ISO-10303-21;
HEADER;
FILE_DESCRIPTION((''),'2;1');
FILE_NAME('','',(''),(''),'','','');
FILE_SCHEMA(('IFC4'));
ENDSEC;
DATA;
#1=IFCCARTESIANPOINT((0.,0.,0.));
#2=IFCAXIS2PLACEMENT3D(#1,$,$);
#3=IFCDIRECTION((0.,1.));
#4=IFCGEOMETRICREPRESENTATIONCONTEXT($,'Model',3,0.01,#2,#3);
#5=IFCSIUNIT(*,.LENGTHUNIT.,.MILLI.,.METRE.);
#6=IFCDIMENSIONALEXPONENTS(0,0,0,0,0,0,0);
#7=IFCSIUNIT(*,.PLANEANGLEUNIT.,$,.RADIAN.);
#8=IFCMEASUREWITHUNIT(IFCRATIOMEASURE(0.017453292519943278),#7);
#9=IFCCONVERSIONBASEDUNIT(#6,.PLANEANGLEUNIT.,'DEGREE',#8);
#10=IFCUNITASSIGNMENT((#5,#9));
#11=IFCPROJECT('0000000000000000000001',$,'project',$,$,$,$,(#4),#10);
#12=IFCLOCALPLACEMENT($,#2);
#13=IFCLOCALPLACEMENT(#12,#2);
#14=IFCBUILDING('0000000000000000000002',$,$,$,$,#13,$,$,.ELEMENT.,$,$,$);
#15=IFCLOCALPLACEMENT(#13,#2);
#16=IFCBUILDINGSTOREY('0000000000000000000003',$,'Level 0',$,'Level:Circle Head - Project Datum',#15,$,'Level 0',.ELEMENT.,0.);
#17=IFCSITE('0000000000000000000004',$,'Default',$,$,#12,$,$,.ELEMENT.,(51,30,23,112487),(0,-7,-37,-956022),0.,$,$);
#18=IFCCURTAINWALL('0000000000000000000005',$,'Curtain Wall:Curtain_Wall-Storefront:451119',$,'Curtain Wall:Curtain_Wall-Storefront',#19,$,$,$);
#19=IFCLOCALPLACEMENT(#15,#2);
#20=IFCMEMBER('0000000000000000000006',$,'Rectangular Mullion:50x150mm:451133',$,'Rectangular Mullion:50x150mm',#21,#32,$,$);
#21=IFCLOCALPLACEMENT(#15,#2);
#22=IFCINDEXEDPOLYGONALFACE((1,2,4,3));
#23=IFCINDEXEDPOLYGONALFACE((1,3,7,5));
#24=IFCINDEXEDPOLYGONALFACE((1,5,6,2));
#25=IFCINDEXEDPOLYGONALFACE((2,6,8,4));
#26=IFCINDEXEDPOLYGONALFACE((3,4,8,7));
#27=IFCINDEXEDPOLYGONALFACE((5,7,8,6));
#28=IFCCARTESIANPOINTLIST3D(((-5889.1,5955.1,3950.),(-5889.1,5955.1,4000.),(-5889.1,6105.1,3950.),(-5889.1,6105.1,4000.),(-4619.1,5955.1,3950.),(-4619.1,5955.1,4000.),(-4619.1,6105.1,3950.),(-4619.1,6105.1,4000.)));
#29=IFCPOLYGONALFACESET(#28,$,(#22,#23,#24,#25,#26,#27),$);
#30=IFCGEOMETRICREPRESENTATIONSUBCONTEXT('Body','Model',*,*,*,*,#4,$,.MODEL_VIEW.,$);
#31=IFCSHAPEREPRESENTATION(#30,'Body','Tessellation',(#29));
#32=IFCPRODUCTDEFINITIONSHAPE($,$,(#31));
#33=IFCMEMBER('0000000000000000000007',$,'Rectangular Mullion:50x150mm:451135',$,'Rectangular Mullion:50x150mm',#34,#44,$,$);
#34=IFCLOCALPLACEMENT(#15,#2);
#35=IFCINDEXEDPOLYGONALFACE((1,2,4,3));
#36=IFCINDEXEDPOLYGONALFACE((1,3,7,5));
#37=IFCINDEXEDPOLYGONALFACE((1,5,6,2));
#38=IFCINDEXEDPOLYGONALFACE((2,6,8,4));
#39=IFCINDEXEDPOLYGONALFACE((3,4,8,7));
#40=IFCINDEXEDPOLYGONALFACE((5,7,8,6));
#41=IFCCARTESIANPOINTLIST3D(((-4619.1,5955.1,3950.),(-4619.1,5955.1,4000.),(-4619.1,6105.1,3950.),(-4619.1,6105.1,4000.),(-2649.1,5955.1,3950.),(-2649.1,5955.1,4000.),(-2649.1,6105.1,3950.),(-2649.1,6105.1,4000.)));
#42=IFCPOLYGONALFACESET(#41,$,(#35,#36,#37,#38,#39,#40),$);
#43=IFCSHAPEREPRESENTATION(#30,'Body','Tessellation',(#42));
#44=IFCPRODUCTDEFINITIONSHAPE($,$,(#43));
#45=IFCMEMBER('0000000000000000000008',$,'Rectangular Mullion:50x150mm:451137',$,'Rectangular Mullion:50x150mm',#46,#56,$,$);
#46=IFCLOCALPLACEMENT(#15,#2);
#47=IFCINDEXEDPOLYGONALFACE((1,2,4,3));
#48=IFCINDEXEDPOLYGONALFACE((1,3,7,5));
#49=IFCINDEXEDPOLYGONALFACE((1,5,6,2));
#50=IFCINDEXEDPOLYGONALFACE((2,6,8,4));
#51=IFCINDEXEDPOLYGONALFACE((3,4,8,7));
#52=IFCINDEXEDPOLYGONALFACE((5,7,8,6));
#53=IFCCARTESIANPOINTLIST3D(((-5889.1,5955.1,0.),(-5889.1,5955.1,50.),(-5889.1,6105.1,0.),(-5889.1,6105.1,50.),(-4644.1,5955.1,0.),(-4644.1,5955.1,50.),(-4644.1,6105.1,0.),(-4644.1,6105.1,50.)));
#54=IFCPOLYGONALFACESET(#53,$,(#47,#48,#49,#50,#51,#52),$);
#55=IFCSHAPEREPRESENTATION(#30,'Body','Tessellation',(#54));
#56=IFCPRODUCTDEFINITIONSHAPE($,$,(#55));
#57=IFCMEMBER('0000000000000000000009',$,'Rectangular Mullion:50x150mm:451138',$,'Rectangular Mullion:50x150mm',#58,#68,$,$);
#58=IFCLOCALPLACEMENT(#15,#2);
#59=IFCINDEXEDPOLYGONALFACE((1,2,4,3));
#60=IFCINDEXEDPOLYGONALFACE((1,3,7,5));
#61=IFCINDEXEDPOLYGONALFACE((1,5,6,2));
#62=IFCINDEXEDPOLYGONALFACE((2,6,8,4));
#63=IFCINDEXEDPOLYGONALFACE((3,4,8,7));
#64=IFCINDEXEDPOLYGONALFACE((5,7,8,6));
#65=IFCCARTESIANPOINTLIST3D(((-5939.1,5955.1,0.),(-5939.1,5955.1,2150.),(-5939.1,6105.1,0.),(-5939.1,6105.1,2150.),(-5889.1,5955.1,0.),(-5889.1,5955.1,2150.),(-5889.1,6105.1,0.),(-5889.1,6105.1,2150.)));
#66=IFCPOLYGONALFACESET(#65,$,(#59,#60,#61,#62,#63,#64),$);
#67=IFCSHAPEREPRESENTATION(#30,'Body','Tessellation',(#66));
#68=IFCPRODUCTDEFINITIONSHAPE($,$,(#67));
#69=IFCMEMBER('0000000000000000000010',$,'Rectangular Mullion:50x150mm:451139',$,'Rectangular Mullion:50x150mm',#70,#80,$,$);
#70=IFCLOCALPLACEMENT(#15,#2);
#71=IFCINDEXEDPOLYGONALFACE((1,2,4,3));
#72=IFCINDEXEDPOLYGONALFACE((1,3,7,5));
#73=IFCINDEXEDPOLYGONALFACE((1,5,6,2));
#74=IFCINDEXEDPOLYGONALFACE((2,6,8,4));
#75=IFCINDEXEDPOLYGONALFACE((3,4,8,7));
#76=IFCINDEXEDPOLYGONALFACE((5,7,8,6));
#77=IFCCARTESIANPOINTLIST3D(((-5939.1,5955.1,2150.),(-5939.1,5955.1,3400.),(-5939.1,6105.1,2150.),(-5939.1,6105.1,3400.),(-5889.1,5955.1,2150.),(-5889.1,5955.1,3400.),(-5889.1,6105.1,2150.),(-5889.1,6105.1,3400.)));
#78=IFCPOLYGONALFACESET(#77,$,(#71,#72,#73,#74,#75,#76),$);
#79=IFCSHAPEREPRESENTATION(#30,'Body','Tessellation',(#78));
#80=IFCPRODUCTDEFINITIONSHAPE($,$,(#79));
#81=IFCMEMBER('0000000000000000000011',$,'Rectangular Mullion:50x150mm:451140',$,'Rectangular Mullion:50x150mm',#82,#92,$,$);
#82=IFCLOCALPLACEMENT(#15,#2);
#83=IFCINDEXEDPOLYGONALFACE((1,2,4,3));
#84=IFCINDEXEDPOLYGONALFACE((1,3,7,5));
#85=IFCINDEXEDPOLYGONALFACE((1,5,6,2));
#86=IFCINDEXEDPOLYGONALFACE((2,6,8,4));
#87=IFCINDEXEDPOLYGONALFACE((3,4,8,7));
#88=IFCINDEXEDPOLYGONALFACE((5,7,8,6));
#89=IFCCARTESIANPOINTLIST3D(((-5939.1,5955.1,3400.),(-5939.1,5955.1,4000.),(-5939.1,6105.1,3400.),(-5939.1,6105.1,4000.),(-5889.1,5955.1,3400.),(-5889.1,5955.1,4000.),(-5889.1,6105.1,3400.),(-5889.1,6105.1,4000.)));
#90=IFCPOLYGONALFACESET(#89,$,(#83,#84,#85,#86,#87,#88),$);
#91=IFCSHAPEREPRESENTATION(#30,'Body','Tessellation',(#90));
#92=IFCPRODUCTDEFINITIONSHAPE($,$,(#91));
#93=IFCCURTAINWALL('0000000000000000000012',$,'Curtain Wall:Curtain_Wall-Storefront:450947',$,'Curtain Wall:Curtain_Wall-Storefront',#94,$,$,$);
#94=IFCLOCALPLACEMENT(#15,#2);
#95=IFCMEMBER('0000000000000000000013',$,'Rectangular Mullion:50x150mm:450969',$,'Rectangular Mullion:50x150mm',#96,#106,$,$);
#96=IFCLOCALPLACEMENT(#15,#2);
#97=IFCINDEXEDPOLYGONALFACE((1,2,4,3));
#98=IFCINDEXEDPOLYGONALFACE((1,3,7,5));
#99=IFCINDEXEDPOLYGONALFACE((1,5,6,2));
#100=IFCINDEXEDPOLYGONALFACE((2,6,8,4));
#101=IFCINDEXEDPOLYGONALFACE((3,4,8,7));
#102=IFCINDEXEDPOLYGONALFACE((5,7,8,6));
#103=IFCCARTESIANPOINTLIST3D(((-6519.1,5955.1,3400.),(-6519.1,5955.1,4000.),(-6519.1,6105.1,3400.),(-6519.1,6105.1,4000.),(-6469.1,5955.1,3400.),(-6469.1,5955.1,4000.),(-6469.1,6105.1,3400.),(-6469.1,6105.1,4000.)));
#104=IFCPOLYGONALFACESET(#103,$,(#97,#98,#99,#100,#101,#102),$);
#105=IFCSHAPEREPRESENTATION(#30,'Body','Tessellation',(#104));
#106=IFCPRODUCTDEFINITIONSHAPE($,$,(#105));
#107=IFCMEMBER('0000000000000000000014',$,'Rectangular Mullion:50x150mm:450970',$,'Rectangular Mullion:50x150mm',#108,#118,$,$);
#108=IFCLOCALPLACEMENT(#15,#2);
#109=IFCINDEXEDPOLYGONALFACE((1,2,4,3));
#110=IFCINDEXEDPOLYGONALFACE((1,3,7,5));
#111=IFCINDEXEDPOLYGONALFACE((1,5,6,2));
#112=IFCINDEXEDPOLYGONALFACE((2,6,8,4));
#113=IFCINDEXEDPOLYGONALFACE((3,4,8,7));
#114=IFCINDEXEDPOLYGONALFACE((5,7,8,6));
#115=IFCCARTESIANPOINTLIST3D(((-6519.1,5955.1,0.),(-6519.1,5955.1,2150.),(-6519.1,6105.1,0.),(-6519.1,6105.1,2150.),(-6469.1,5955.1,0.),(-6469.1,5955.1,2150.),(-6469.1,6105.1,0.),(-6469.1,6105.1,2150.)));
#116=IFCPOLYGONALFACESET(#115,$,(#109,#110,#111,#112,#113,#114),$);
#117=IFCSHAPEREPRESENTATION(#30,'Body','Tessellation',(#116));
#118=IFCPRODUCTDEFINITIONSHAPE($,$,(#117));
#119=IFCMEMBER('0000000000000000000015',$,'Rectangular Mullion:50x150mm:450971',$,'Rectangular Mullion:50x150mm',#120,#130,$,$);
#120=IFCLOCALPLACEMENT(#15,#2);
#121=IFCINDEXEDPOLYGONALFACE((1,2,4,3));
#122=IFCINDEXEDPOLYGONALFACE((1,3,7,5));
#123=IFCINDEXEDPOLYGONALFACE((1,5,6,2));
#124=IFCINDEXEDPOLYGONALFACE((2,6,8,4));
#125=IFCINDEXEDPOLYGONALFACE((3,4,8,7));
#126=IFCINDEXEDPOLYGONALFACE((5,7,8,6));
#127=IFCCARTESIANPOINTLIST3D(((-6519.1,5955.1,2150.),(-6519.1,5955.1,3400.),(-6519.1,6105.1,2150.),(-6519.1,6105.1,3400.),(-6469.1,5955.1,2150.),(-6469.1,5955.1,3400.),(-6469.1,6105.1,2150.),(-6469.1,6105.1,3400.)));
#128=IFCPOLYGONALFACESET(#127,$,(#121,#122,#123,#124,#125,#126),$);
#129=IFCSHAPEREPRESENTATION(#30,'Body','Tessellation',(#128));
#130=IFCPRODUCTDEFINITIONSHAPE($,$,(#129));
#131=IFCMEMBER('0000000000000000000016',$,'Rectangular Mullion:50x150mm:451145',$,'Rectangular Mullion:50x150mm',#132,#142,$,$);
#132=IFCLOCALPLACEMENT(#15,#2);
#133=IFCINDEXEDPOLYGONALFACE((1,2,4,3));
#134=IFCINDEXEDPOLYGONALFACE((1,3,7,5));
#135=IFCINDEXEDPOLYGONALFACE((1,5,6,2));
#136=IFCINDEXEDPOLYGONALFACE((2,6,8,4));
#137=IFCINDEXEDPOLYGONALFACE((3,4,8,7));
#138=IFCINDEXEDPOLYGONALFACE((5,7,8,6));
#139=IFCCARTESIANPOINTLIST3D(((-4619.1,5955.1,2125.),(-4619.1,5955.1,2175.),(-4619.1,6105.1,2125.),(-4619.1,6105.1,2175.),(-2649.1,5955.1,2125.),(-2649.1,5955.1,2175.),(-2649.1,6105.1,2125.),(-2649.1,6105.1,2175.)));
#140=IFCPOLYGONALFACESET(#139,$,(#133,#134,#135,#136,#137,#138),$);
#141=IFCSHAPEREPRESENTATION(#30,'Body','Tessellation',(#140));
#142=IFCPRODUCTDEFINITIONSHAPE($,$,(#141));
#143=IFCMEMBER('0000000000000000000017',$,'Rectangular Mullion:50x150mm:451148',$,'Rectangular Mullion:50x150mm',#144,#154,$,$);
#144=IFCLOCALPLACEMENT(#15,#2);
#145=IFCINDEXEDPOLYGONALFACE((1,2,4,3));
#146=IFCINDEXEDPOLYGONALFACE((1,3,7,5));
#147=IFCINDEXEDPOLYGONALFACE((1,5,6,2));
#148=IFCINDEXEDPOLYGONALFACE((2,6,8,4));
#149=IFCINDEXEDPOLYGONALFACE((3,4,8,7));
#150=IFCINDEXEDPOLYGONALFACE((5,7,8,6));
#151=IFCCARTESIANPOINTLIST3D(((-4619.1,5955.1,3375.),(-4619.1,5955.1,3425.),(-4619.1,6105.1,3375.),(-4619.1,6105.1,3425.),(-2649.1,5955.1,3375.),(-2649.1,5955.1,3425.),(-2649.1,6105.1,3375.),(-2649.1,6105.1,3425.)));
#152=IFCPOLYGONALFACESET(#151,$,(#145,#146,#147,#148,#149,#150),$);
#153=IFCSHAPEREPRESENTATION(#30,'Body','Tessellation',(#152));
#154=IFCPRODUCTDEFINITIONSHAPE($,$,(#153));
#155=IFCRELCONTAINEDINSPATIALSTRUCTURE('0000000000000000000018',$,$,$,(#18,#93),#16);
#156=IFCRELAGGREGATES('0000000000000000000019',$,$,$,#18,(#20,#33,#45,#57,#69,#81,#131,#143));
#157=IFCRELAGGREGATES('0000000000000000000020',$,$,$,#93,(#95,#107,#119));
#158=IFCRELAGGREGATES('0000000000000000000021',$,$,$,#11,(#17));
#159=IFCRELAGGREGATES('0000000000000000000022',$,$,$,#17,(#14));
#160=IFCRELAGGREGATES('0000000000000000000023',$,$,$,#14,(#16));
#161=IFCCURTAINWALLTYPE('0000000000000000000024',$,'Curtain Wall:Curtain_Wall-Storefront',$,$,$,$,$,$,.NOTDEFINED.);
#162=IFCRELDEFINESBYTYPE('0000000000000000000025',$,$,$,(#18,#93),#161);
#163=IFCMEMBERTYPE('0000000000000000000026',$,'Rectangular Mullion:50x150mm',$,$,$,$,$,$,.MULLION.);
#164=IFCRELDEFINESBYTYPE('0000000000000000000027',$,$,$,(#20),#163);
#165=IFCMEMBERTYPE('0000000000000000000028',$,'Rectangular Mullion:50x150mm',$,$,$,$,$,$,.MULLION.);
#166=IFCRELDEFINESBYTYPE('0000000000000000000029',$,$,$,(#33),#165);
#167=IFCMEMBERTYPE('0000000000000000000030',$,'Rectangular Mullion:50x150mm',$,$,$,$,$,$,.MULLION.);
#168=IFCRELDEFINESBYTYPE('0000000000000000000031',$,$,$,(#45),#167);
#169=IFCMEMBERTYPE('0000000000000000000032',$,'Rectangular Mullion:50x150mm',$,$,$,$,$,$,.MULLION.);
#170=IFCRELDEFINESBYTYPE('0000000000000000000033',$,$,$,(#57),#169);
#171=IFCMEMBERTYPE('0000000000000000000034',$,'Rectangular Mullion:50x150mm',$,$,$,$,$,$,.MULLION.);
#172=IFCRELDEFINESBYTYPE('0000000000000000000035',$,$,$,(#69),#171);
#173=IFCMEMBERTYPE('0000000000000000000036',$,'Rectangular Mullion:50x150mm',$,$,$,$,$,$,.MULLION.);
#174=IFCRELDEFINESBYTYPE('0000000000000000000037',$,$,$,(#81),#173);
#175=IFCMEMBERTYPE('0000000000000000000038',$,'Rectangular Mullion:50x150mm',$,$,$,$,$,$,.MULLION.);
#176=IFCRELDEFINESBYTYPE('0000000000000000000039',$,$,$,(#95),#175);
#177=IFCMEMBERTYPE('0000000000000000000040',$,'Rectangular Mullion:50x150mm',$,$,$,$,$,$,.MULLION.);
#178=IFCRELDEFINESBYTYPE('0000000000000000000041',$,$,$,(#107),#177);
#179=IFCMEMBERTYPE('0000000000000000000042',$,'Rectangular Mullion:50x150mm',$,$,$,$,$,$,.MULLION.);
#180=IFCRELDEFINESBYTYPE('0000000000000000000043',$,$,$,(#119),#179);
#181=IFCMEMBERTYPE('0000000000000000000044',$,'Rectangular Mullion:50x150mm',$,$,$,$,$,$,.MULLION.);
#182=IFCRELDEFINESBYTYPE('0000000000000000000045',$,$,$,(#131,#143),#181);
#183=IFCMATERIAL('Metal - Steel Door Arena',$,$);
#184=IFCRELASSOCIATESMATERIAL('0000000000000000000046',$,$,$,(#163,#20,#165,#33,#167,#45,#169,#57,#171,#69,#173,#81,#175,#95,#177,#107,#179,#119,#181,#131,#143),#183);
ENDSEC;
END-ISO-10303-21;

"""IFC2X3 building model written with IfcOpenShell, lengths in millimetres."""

from ifc_helpers import new_model, entity, si_unit, converted_unit, direction, frame, origin, origin_2d_with_axis, place, context, subcontext, project, spatial, rectangle, extrude, source, transform, mapped, material, type_object, type_shapes, element, aggregate, save


model = new_model("IFC2X3")

# Units and contexts
model_context = context("Model", 3, precision=0.01, world=origin(), true_north=direction((0.0, 1.0)))
body_context = subcontext(model_context, "Body", "Model", "MODEL_VIEW")
ifc_project = project(units=[si_unit("LENGTHUNIT", "METRE", prefix="MILLI"), converted_unit("PLANEANGLEUNIT", "DEGREE", entity("IfcRatioMeasure", 0.017453292519943278), si_unit("PLANEANGLEUNIT", "RADIAN"), dimensions=[0, 0, 0, 0, 0, 0, 0])], contexts=[model_context])

# Site, building, storey
site_placement = place(None, origin())
site = spatial("IfcSite", under=ifc_project, at=site_placement, Name="Default", CompositionType="ELEMENT", RefLatitude=(51, 30, 23, 112487), RefLongitude=(0, -7, -37, -956022), RefElevation=0.0)
building_placement = place(site_placement, origin())
building = spatial("IfcBuilding", under=site, at=building_placement, CompositionType="ELEMENT")
storey_placement = place(building_placement, origin())
storey = spatial("IfcBuildingStorey", under=building, at=storey_placement, Name="Level 0", ObjectType="Level:Circle Head - Project Datum", LongName="Level 0", CompositionType="ELEMENT", Elevation=0.0)

# Curtain walls, members
curtain_wall_type = type_object("IfcCurtainWallType", Name="Curtain Wall:Curtain_Wall-Storefront", PredefinedType="NOTDEFINED")
curtain_wall_1_placement = place(storey_placement, origin())
curtain_wall_1 = element("IfcCurtainWall", 1, at=curtain_wall_1_placement, inside=storey, type_object=curtain_wall_type, Name="Curtain Wall:Curtain_Wall-Storefront:451119", ObjectType="Curtain Wall:Curtain_Wall-Storefront")
ifc_material_1 = material(Name="Metal - Steel Door Arena")
member_type_1 = type_object("IfcMemberType", Name="Rectangular Mullion:50x150mm", PredefinedType="MULLION", material=ifc_material_1)
shared_shape_1 = source(origin(), body_context, "Body", "SweptSolid", [
    extrude(rectangle(XDim=150.0, YDim=50.0, at=origin_2d_with_axis()), frame((-25.0, 0.0, -1270.0), z_axis=(0.0, 0.0, 1.0), x_axis=(0.0, -1.0, 0.0)), (0.0, 0.0, 1.0), 1270.0),
])
type_shapes(member_type_1, [shared_shape_1])
member_1_placement = place(curtain_wall_1_placement, frame((-5889.1, 6030.1, 4000.0), z_axis=(-1.0, 0.0, 0.0), x_axis=(0.0, 0.0, 1.0)))
member_1 = element("IfcMember", 2, at=member_1_placement, type_object=member_type_1, material=ifc_material_1, Name="Rectangular Mullion:50x150mm:451133", ObjectType="Rectangular Mullion:50x150mm", context=body_context, shape_type="MappedRepresentation", body=[
    mapped(shared_shape_1, transform((0.0, 0.0, 0.0), scale=1.0)),
])
member_type_2 = type_object("IfcMemberType", Name="Rectangular Mullion:50x150mm", PredefinedType="MULLION", material=ifc_material_1)
shared_shape_2 = source(origin(), body_context, "Body", "SweptSolid", [
    extrude(rectangle(XDim=150.0, YDim=50.0, at=origin_2d_with_axis()), frame((-25.0, 0.0, -1970.0), z_axis=(0.0, 0.0, 1.0), x_axis=(0.0, -1.0, 0.0)), (0.0, 0.0, 1.0), 1970.0),
])
type_shapes(member_type_2, [shared_shape_2])
member_2_placement = place(curtain_wall_1_placement, frame((-4619.1, 6030.1, 4000.0), z_axis=(-1.0, 0.0, 0.0), x_axis=(0.0, 0.0, 1.0)))
member_2 = element("IfcMember", 3, at=member_2_placement, type_object=member_type_2, material=ifc_material_1, Name="Rectangular Mullion:50x150mm:451135", ObjectType="Rectangular Mullion:50x150mm", context=body_context, shape_type="MappedRepresentation", body=[
    mapped(shared_shape_2, transform((0.0, 0.0, 0.0), scale=1.0)),
])
member_type_3 = type_object("IfcMemberType", Name="Rectangular Mullion:50x150mm", PredefinedType="MULLION", material=ifc_material_1)
shared_shape_3 = source(origin(), body_context, "Body", "SweptSolid", [
    extrude(rectangle(XDim=150.0, YDim=50.0, at=origin_2d_with_axis()), frame((-25.0, 0.0, -1245.0), z_axis=(0.0, 0.0, 1.0), x_axis=(0.0, -1.0, 0.0)), (0.0, 0.0, 1.0), 1245.0),
])
type_shapes(member_type_3, [shared_shape_3])
member_3_placement = place(curtain_wall_1_placement, frame((-4644.1, 6030.1, 0.0), z_axis=(1.0, 0.0, 0.0), x_axis=(0.0, 0.0, -1.0)))
member_3 = element("IfcMember", 4, at=member_3_placement, type_object=member_type_3, material=ifc_material_1, Name="Rectangular Mullion:50x150mm:451137", ObjectType="Rectangular Mullion:50x150mm", context=body_context, shape_type="MappedRepresentation", body=[
    mapped(shared_shape_3, transform((0.0, 0.0, 0.0), scale=1.0)),
])
member_type_4 = type_object("IfcMemberType", Name="Rectangular Mullion:50x150mm", PredefinedType="MULLION", material=ifc_material_1)
shared_shape_4 = source(origin(), body_context, "Body", "SweptSolid", [
    extrude(rectangle(XDim=150.0, YDim=50.0, at=origin_2d_with_axis()), frame((-25.0, 0.0, -2150.0), z_axis=(0.0, 0.0, 1.0), x_axis=(0.0, -1.0, 0.0)), (0.0, 0.0, 1.0), 2150.0),
])
type_shapes(member_type_4, [shared_shape_4])
member_4_placement = place(curtain_wall_1_placement, frame((-5939.1, 6030.1, 0.0), z_axis=(0.0, 0.0, -1.0), x_axis=(-1.0, 0.0, 0.0)))
member_4 = element("IfcMember", 5, at=member_4_placement, type_object=member_type_4, material=ifc_material_1, Name="Rectangular Mullion:50x150mm:451138", ObjectType="Rectangular Mullion:50x150mm", context=body_context, shape_type="MappedRepresentation", body=[
    mapped(shared_shape_4, transform((0.0, 0.0, 0.0), scale=1.0)),
])
member_type_5 = type_object("IfcMemberType", Name="Rectangular Mullion:50x150mm", PredefinedType="MULLION", material=ifc_material_1)
shared_shape_5 = source(origin(), body_context, "Body", "SweptSolid", [
    extrude(rectangle(XDim=150.0, YDim=50.0, at=origin_2d_with_axis()), frame((-25.0, 0.0, -1250.0), z_axis=(0.0, 0.0, 1.0), x_axis=(0.0, -1.0, 0.0)), (0.0, 0.0, 1.0), 1250.0),
])
type_shapes(member_type_5, [shared_shape_5])
member_5_placement = place(curtain_wall_1_placement, frame((-5939.1, 6030.1, 2150.0), z_axis=(0.0, 0.0, -1.0), x_axis=(-1.0, 0.0, 0.0)))
member_5 = element("IfcMember", 6, at=member_5_placement, type_object=member_type_5, material=ifc_material_1, Name="Rectangular Mullion:50x150mm:451139", ObjectType="Rectangular Mullion:50x150mm", context=body_context, shape_type="MappedRepresentation", body=[
    mapped(shared_shape_5, transform((0.0, 0.0, 0.0), scale=1.0)),
])
member_type_6 = type_object("IfcMemberType", Name="Rectangular Mullion:50x150mm", PredefinedType="MULLION", material=ifc_material_1)
shared_shape_6 = source(origin(), body_context, "Body", "SweptSolid", [
    extrude(rectangle(XDim=150.0, YDim=50.0, at=origin_2d_with_axis()), frame((-25.0, 0.0, -600.0), z_axis=(0.0, 0.0, 1.0), x_axis=(0.0, -1.0, 0.0)), (0.0, 0.0, 1.0), 600.0),
])
type_shapes(member_type_6, [shared_shape_6])
member_6_placement = place(curtain_wall_1_placement, frame((-5939.1, 6030.1, 3400.0), z_axis=(0.0, 0.0, -1.0), x_axis=(-1.0, 0.0, 0.0)))
member_6 = element("IfcMember", 7, at=member_6_placement, type_object=member_type_6, material=ifc_material_1, Name="Rectangular Mullion:50x150mm:451140", ObjectType="Rectangular Mullion:50x150mm", context=body_context, shape_type="MappedRepresentation", body=[
    mapped(shared_shape_6, transform((0.0, 0.0, 0.0), scale=1.0)),
])
curtain_wall_2_placement = place(storey_placement, origin())
curtain_wall_2 = element("IfcCurtainWall", 8, at=curtain_wall_2_placement, inside=storey, type_object=curtain_wall_type, Name="Curtain Wall:Curtain_Wall-Storefront:450947", ObjectType="Curtain Wall:Curtain_Wall-Storefront")
member_type_7 = type_object("IfcMemberType", Name="Rectangular Mullion:50x150mm", PredefinedType="MULLION", material=ifc_material_1)
shared_shape_7 = source(origin(), body_context, "Body", "SweptSolid", [
    extrude(rectangle(XDim=150.0, YDim=50.0, at=origin_2d_with_axis()), frame((-25.0, 0.0, -600.0), z_axis=(0.0, 0.0, 1.0), x_axis=(0.0, -1.0, 0.0)), (0.0, 0.0, 1.0), 600.0),
])
type_shapes(member_type_7, [shared_shape_7])
member_7_placement = place(curtain_wall_2_placement, frame((-6469.1, 6030.1, 4000.0)))
member_7 = element("IfcMember", 9, at=member_7_placement, type_object=member_type_7, material=ifc_material_1, Name="Rectangular Mullion:50x150mm:450969", ObjectType="Rectangular Mullion:50x150mm", context=body_context, shape_type="MappedRepresentation", body=[
    mapped(shared_shape_7, transform((0.0, 0.0, 0.0), scale=1.0)),
])
member_type_8 = type_object("IfcMemberType", Name="Rectangular Mullion:50x150mm", PredefinedType="MULLION", material=ifc_material_1)
shared_shape_8 = source(origin(), body_context, "Body", "SweptSolid", [
    extrude(rectangle(XDim=150.0, YDim=50.0, at=origin_2d_with_axis()), frame((-25.0, 0.0, -2150.0), z_axis=(0.0, 0.0, 1.0), x_axis=(0.0, -1.0, 0.0)), (0.0, 0.0, 1.0), 2150.0),
])
type_shapes(member_type_8, [shared_shape_8])
member_8_placement = place(curtain_wall_2_placement, frame((-6469.1, 6030.1, 2150.0)))
member_8 = element("IfcMember", 10, at=member_8_placement, type_object=member_type_8, material=ifc_material_1, Name="Rectangular Mullion:50x150mm:450970", ObjectType="Rectangular Mullion:50x150mm", context=body_context, shape_type="MappedRepresentation", body=[
    mapped(shared_shape_8, transform((0.0, 0.0, 0.0), scale=1.0)),
])
member_type_9 = type_object("IfcMemberType", Name="Rectangular Mullion:50x150mm", PredefinedType="MULLION", material=ifc_material_1)
shared_shape_9 = source(origin(), body_context, "Body", "SweptSolid", [
    extrude(rectangle(XDim=150.0, YDim=50.0, at=origin_2d_with_axis()), frame((-25.0, 0.0, -1250.0), z_axis=(0.0, 0.0, 1.0), x_axis=(0.0, -1.0, 0.0)), (0.0, 0.0, 1.0), 1250.0),
])
type_shapes(member_type_9, [shared_shape_9])
member_9_placement = place(curtain_wall_2_placement, frame((-6469.1, 6030.1, 3400.0)))
member_9 = element("IfcMember", 11, at=member_9_placement, type_object=member_type_9, material=ifc_material_1, Name="Rectangular Mullion:50x150mm:450971", ObjectType="Rectangular Mullion:50x150mm", context=body_context, shape_type="MappedRepresentation", body=[
    mapped(shared_shape_9, transform((0.0, 0.0, 0.0), scale=1.0)),
])

# Members
member_type_10 = type_object("IfcMemberType", Name="Rectangular Mullion:50x150mm", PredefinedType="MULLION", material=ifc_material_1)
shared_shape_10 = source(origin(), body_context, "Body", "SweptSolid", [
    extrude(rectangle(XDim=150.0, YDim=50.0, at=origin_2d_with_axis()), frame((0.0, 0.0, -1970.0), z_axis=(0.0, 0.0, 1.0), x_axis=(0.0, -1.0, 0.0)), (0.0, 0.0, 1.0), 1970.0),
])
type_shapes(member_type_10, [shared_shape_10])
member_10_placement = place(curtain_wall_1_placement, frame((-4619.1, 6030.1, 2150.0), z_axis=(-1.0, 0.0, 0.0), x_axis=(0.0, 0.0, 1.0)))
member_10 = element("IfcMember", 12, at=member_10_placement, type_object=member_type_10, material=ifc_material_1, Name="Rectangular Mullion:50x150mm:451145", ObjectType="Rectangular Mullion:50x150mm", context=body_context, shape_type="MappedRepresentation", body=[
    mapped(shared_shape_10, transform((0.0, 0.0, 0.0), scale=1.0)),
])
member_11_placement = place(curtain_wall_1_placement, frame((-4619.1, 6030.1, 3400.0), z_axis=(-1.0, 0.0, 0.0), x_axis=(0.0, 0.0, 1.0)))
member_11 = element("IfcMember", 13, at=member_11_placement, type_object=member_type_10, material=ifc_material_1, Name="Rectangular Mullion:50x150mm:451148", ObjectType="Rectangular Mullion:50x150mm", context=body_context, shape_type="MappedRepresentation", body=[
    mapped(shared_shape_10, transform((0.0, 0.0, 0.0), scale=1.0)),
])

aggregate(curtain_wall_1, [member_1, member_2, member_3, member_4, member_5, member_6, member_10, member_11])
aggregate(curtain_wall_2, [member_7, member_8, member_9])

save(model, "model.ifc")
